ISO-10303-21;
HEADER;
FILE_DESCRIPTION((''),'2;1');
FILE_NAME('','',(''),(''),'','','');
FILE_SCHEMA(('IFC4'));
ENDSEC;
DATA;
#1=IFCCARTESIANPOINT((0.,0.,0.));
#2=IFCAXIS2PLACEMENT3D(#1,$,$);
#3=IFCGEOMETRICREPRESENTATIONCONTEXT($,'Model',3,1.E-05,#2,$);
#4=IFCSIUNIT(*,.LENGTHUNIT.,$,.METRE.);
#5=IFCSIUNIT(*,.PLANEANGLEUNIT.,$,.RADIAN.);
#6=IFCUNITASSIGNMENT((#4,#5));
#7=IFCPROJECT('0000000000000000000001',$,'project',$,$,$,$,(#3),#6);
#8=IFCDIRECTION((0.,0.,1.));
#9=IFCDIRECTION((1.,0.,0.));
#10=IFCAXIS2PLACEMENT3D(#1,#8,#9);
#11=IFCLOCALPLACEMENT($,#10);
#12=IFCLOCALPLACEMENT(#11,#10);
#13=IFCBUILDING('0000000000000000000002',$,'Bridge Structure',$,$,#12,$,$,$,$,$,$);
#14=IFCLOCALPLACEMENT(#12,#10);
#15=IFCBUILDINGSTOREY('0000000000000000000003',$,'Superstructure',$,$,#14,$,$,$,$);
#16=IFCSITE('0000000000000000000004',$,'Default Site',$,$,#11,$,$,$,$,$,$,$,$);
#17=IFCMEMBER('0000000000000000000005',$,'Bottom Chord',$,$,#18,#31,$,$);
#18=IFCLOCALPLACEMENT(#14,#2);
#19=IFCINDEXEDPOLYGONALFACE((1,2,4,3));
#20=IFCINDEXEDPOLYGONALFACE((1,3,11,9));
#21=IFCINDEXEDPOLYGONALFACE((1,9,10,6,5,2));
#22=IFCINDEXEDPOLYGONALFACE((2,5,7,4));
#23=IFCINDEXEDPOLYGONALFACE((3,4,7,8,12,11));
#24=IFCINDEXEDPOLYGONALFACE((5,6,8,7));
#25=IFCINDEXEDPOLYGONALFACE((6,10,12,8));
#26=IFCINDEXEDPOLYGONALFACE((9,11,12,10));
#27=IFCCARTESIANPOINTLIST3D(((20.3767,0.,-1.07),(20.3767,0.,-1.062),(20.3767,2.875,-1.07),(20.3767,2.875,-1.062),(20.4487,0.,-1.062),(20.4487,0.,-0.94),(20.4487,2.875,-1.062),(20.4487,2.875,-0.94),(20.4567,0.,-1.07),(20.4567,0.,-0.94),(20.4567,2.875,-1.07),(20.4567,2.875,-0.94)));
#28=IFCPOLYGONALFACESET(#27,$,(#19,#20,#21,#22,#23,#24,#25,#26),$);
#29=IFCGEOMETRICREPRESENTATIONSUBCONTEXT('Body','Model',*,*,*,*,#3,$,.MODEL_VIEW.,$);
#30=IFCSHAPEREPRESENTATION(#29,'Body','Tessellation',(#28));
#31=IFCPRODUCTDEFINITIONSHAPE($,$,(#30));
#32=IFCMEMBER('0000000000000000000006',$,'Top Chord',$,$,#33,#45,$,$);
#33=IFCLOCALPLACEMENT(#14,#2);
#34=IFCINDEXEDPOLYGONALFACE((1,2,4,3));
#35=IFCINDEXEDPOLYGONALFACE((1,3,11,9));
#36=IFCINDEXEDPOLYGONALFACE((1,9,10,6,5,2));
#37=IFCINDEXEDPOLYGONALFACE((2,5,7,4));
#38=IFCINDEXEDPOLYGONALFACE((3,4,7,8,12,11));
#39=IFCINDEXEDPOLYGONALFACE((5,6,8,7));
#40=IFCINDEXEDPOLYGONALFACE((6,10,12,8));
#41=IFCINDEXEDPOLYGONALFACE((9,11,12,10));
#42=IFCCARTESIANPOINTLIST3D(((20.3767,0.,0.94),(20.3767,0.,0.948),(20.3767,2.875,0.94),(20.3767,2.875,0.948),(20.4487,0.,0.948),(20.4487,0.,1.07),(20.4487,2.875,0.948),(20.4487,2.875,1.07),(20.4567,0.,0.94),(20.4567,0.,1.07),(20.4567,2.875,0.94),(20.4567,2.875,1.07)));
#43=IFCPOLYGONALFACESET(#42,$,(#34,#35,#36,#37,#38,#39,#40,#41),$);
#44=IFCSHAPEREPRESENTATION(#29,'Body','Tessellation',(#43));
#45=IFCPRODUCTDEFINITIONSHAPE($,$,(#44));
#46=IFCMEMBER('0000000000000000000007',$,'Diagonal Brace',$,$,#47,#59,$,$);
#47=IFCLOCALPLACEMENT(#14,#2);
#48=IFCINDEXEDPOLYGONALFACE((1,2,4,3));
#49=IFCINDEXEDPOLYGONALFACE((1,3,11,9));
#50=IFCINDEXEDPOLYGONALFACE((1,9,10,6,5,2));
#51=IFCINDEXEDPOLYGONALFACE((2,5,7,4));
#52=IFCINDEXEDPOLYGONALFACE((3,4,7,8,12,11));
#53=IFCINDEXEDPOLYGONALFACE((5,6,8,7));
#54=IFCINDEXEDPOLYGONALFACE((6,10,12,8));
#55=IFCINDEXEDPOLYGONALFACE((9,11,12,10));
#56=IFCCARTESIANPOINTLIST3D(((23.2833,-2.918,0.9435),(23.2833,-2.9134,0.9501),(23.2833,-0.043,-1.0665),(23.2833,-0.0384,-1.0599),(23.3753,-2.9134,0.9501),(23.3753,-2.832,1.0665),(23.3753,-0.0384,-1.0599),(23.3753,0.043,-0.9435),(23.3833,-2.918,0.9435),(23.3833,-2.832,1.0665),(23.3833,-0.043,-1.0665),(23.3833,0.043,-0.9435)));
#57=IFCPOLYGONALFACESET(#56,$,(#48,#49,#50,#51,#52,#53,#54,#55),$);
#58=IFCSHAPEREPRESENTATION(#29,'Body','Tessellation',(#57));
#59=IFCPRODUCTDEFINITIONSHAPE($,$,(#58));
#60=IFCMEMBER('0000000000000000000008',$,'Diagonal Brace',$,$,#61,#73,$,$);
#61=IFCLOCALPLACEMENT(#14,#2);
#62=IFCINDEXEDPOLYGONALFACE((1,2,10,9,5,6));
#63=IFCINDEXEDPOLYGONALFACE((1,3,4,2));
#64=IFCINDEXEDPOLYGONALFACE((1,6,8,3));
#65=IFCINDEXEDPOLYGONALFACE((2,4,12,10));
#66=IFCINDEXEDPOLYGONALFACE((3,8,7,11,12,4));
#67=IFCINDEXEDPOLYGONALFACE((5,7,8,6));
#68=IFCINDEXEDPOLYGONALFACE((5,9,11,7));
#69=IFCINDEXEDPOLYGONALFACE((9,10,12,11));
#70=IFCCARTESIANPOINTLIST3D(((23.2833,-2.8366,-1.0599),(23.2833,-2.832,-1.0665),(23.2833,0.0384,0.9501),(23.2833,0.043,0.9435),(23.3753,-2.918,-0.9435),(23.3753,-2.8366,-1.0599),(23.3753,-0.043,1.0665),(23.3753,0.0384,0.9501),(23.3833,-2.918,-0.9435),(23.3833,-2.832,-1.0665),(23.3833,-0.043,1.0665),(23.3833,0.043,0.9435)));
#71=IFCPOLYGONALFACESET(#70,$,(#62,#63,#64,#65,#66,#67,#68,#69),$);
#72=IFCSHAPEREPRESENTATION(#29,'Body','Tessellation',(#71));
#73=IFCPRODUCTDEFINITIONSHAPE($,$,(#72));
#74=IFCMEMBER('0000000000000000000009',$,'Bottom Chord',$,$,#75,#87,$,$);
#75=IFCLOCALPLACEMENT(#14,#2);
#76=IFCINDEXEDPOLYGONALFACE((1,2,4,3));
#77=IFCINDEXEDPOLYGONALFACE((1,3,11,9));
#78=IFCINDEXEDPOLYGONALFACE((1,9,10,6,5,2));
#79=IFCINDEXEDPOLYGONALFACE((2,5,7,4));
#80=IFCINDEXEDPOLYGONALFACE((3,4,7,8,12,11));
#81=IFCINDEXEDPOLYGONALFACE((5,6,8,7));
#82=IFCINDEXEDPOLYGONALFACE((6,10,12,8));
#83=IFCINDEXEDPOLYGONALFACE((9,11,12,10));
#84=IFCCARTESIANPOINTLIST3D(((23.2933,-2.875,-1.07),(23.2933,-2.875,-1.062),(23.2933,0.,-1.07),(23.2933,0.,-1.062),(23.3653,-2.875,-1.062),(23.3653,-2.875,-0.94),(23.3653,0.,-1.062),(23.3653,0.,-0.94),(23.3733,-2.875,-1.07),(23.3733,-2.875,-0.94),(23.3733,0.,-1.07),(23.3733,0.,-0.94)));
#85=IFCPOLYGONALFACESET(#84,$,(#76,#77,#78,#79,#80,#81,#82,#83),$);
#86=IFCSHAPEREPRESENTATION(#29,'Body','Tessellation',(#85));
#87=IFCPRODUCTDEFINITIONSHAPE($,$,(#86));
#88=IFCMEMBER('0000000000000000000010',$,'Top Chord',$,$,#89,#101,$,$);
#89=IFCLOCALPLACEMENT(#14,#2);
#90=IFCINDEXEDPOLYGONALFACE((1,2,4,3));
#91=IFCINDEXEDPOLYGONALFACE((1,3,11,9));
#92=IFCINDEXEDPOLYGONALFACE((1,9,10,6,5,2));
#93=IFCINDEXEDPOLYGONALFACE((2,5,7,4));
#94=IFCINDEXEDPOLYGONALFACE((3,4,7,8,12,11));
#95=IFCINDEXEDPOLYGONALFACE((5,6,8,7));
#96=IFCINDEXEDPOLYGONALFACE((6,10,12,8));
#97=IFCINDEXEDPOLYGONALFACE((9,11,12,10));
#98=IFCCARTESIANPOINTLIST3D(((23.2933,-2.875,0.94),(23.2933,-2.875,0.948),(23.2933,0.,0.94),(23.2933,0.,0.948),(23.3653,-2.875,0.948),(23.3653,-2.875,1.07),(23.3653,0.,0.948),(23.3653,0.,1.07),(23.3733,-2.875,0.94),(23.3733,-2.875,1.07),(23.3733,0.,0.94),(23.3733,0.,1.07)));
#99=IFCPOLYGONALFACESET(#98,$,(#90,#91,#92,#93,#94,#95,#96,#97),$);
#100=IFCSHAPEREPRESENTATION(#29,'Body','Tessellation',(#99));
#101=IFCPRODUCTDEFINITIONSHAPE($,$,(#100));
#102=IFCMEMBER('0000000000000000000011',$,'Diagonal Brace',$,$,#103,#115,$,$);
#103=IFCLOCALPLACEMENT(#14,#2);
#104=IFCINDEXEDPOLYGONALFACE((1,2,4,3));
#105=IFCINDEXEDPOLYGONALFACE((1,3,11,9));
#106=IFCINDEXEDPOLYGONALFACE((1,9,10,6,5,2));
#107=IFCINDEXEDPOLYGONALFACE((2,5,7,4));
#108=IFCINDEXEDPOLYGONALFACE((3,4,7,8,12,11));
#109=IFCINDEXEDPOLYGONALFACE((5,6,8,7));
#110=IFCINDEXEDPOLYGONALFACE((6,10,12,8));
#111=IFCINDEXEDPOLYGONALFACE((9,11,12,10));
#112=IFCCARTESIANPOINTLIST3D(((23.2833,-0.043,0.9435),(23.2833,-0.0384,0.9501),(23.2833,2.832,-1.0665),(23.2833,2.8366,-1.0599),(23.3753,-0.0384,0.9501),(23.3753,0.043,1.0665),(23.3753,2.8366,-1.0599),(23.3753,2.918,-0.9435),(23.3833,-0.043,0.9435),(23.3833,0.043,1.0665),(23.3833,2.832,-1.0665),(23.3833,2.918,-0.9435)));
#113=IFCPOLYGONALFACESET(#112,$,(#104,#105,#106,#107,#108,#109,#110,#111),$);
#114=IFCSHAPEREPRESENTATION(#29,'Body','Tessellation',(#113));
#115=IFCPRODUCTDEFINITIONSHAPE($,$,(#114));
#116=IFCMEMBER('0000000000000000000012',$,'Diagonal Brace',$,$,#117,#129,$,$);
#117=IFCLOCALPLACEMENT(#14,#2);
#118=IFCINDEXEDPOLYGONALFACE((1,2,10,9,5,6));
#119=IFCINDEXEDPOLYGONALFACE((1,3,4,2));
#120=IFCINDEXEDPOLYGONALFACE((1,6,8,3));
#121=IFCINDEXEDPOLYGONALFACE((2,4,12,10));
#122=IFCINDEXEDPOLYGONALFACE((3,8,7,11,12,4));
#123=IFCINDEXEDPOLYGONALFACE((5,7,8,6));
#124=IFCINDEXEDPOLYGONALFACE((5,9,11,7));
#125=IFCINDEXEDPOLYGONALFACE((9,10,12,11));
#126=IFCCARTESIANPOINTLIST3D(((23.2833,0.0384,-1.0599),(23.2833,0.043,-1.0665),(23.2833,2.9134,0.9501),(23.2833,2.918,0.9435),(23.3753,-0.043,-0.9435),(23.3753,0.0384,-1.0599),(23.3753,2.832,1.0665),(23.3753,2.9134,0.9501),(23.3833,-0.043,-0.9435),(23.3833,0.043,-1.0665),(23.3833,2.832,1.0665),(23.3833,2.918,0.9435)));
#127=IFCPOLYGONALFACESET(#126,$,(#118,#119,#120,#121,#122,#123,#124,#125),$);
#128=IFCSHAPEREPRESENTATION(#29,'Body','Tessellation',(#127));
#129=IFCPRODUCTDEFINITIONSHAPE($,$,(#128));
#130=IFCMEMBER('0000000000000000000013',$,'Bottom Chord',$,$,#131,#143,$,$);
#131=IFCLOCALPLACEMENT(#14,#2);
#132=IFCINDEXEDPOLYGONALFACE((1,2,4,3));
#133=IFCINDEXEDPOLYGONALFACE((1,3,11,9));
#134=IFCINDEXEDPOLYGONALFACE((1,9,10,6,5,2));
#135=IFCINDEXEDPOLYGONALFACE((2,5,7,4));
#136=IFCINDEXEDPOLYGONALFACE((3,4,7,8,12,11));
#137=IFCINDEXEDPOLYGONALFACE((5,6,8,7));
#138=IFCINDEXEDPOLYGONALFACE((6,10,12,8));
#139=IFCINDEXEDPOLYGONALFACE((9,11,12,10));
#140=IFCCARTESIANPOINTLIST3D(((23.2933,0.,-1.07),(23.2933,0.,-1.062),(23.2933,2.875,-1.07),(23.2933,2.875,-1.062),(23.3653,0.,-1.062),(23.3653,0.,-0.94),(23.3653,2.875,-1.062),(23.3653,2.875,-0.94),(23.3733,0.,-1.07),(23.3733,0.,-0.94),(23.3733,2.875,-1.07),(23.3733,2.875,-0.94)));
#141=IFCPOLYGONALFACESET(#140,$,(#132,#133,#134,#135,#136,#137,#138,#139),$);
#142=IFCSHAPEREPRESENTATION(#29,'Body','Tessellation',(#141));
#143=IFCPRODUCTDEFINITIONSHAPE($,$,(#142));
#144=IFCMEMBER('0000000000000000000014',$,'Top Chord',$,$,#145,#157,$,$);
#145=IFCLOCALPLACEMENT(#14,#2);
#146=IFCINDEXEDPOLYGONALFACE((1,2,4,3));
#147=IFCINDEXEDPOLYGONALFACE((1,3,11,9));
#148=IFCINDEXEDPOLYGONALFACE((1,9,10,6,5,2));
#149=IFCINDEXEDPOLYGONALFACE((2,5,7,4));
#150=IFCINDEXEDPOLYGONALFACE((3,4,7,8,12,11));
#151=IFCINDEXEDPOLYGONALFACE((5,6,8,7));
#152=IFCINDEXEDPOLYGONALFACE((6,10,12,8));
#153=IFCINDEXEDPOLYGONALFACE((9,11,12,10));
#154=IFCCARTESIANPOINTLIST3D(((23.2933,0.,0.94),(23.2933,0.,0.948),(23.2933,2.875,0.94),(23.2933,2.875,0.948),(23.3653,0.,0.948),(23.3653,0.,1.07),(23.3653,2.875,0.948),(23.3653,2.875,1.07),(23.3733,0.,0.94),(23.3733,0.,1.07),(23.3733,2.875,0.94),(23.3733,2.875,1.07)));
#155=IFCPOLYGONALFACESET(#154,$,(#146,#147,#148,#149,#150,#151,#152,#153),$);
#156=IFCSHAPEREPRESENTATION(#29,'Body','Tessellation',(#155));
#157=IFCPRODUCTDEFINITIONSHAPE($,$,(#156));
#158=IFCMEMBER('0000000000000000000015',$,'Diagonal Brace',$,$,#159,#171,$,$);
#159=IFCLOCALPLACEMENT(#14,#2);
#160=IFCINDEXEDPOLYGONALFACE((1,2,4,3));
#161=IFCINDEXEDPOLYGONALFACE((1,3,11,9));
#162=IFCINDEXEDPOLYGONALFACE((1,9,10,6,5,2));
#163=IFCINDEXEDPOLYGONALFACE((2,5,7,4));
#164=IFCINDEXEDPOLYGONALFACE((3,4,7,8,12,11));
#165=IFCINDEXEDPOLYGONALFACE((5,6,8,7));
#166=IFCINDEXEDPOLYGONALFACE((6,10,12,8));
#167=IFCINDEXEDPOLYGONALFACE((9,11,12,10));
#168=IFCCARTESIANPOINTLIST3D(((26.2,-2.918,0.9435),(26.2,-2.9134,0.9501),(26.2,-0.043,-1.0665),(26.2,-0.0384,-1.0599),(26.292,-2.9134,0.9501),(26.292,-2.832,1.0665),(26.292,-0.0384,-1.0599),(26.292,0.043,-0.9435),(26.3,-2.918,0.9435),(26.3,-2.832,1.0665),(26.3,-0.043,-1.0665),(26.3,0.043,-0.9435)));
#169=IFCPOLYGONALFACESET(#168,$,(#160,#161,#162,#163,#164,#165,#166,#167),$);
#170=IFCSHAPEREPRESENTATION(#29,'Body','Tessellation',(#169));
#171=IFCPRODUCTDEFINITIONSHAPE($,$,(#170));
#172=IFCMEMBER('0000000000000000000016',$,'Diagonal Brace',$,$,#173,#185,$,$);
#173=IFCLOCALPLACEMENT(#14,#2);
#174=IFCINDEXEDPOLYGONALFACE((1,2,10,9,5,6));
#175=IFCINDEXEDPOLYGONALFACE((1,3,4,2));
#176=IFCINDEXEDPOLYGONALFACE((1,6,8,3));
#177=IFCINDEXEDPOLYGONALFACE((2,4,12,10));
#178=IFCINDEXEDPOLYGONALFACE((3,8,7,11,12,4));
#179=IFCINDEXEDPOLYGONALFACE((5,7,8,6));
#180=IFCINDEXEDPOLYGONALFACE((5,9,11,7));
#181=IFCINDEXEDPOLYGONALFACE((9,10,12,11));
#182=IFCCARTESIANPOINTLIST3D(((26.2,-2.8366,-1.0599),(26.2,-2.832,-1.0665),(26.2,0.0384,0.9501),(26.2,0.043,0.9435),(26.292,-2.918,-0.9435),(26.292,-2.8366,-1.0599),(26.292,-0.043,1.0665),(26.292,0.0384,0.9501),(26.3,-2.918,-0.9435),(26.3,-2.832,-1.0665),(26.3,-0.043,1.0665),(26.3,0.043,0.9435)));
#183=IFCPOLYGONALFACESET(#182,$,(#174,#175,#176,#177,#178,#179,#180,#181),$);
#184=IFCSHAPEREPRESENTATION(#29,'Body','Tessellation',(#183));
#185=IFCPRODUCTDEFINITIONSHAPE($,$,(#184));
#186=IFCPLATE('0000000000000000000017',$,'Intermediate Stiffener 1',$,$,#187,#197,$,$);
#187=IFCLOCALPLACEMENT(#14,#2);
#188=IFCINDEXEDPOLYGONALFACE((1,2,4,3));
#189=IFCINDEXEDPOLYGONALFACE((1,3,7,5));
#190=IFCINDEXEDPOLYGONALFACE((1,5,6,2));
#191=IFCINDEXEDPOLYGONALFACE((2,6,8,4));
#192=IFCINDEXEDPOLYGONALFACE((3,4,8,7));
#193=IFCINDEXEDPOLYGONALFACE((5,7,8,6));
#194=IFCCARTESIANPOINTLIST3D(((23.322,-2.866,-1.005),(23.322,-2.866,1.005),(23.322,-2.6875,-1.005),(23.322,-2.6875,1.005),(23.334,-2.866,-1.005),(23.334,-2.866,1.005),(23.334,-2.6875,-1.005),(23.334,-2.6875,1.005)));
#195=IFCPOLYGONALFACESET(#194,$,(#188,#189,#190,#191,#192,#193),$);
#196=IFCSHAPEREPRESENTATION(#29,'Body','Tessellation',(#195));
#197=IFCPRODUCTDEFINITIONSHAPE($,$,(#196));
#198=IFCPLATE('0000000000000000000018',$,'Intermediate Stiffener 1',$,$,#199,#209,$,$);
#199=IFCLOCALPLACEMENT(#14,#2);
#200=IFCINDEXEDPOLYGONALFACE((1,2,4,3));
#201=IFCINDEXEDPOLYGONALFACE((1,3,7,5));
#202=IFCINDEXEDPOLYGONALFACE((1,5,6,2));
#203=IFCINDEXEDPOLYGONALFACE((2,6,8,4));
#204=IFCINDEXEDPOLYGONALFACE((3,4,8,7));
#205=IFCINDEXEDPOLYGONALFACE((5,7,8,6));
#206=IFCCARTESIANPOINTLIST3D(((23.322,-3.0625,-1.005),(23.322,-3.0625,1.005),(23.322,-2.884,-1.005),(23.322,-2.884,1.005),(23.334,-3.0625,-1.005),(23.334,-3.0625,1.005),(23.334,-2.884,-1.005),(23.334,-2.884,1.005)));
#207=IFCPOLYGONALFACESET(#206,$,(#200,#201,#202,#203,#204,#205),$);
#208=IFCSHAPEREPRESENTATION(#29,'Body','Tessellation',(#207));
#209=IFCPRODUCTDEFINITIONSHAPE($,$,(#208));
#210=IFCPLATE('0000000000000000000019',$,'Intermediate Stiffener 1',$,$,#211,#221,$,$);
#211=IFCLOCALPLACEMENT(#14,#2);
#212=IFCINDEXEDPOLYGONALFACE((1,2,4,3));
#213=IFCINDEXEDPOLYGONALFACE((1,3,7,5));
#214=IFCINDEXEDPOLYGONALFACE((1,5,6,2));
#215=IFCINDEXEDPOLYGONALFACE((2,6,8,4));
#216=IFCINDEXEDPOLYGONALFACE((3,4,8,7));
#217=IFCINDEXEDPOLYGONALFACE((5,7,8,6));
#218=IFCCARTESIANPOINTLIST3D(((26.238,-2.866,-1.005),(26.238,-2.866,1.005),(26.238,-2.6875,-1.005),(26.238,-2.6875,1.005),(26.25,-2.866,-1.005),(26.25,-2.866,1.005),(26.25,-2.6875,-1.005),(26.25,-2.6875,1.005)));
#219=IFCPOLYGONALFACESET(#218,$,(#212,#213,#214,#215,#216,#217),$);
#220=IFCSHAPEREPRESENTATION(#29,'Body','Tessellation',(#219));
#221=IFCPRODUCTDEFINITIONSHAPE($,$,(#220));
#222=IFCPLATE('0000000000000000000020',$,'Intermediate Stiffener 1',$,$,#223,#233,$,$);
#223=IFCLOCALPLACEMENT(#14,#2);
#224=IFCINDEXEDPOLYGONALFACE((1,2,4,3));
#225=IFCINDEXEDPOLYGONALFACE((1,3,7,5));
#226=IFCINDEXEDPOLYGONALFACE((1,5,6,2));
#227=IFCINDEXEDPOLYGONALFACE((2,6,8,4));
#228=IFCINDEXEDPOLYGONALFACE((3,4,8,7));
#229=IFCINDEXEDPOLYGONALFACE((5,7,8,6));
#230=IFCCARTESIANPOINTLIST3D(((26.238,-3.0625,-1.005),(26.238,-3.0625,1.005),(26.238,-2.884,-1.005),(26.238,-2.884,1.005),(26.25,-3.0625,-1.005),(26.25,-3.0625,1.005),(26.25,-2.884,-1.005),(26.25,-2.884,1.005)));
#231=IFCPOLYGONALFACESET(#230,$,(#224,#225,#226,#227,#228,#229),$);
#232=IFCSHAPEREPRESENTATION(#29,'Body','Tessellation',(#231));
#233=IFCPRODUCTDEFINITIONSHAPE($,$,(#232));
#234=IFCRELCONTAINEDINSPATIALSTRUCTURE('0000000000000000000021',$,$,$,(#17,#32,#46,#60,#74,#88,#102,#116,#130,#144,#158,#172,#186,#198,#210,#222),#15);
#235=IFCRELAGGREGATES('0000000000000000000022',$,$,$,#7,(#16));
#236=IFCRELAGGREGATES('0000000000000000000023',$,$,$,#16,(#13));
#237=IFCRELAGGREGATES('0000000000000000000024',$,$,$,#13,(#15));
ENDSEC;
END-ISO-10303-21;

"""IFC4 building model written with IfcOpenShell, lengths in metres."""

from ifc_helpers import new_model, si_unit, frame, origin, origin_with_axes, origin_2d_with_axis, place, context, subcontext, project, spatial, rectangle, l_section, extrude, element, save


model = new_model("IFC4")

# Units and contexts
model_context = context("Model", 3, precision=1e-05, world=origin())
body_context = subcontext(model_context, "Body", "Model", "MODEL_VIEW")
ifc_project = project(units=[si_unit("LENGTHUNIT", "METRE"), si_unit("PLANEANGLEUNIT", "RADIAN")], contexts=[model_context])

# Site, building, storey
site_placement = place(None, origin_with_axes())
site = spatial("IfcSite", under=ifc_project, at=site_placement, Name="Default Site")
building_placement = place(site_placement, origin_with_axes())
building = spatial("IfcBuilding", under=site, at=building_placement, Name="Bridge Structure")
storey_placement = place(building_placement, origin_with_axes())
storey = spatial("IfcBuildingStorey", under=building, at=storey_placement, Name="Superstructure")

# Members
for number, where, z_axis, x_axis, name in (
    (1, (20.4167, 0.0, -1.005), (0.0, 1.0, 0.0), (-1.0, 0.0, 0.0), "Bottom Chord"),
    (2, (20.4167, 0.0, 1.005), (0.0, 1.0, 0.0), (-1.0, 0.0, 0.0), "Top Chord"),
):
    element("IfcMember", number, at=place(storey_placement, frame(where, z_axis=z_axis, x_axis=x_axis)), inside=storey, Name=name, context=body_context, shape_type="SweptSolid", body=[
        extrude(l_section(Depth=0.13, Width=0.08, Thickness=0.008, at=origin_2d_with_axis()), origin_with_axes(), (0.0, 0.0, 1.0), 2.875),
    ])
for number, where, z_axis, x_axis, name in (
    (3, (23.3333, -2.875, 1.005), (0.0, 0.819567, -0.572984), (-1.0, 0.0, 0.0), "Diagonal Brace"),
    (4, (23.3333, -2.875, -1.005), (0.0, 0.819567, 0.572984), (-1.0, 0.0, 0.0), "Diagonal Brace"),
):
    element("IfcMember", number, at=place(storey_placement, frame(where, z_axis=z_axis, x_axis=x_axis)), inside=storey, Name=name, context=body_context, shape_type="SweptSolid", body=[
        extrude(l_section(Depth=0.15, Width=0.1, Thickness=0.008, at=origin_2d_with_axis()), origin_with_axes(), (0.0, 0.0, 1.0), 3.508),
    ])
for number, where, z_axis, x_axis, name in (
    (5, (23.3333, -2.875, -1.005), (0.0, 1.0, 0.0), (-1.0, 0.0, 0.0), "Bottom Chord"),
    (6, (23.3333, -2.875, 1.005), (0.0, 1.0, 0.0), (-1.0, 0.0, 0.0), "Top Chord"),
):
    element("IfcMember", number, at=place(storey_placement, frame(where, z_axis=z_axis, x_axis=x_axis)), inside=storey, Name=name, context=body_context, shape_type="SweptSolid", body=[
        extrude(l_section(Depth=0.13, Width=0.08, Thickness=0.008, at=origin_2d_with_axis()), origin_with_axes(), (0.0, 0.0, 1.0), 2.875),
    ])
for number, where, z_axis, x_axis, name in (
    (7, (23.3333, 0.0, 1.005), (0.0, 0.819567, -0.572984), (-1.0, 0.0, 0.0), "Diagonal Brace"),
    (8, (23.3333, 0.0, -1.005), (0.0, 0.819567, 0.572984), (-1.0, 0.0, 0.0), "Diagonal Brace"),
):
    element("IfcMember", number, at=place(storey_placement, frame(where, z_axis=z_axis, x_axis=x_axis)), inside=storey, Name=name, context=body_context, shape_type="SweptSolid", body=[
        extrude(l_section(Depth=0.15, Width=0.1, Thickness=0.008, at=origin_2d_with_axis()), origin_with_axes(), (0.0, 0.0, 1.0), 3.508),
    ])
for number, where, z_axis, x_axis, name in (
    (9, (23.3333, 0.0, -1.005), (0.0, 1.0, 0.0), (-1.0, 0.0, 0.0), "Bottom Chord"),
    (10, (23.3333, 0.0, 1.005), (0.0, 1.0, 0.0), (-1.0, 0.0, 0.0), "Top Chord"),
):
    element("IfcMember", number, at=place(storey_placement, frame(where, z_axis=z_axis, x_axis=x_axis)), inside=storey, Name=name, context=body_context, shape_type="SweptSolid", body=[
        extrude(l_section(Depth=0.13, Width=0.08, Thickness=0.008, at=origin_2d_with_axis()), origin_with_axes(), (0.0, 0.0, 1.0), 2.875),
    ])
for number, where, z_axis, x_axis, name in (
    (11, (26.25, -2.875, 1.005), (0.0, 0.819567, -0.572984), (-1.0, 0.0, 0.0), "Diagonal Brace"),
    (12, (26.25, -2.875, -1.005), (0.0, 0.819567, 0.572984), (-1.0, 0.0, 0.0), "Diagonal Brace"),
):
    element("IfcMember", number, at=place(storey_placement, frame(where, z_axis=z_axis, x_axis=x_axis)), inside=storey, Name=name, context=body_context, shape_type="SweptSolid", body=[
        extrude(l_section(Depth=0.15, Width=0.1, Thickness=0.008, at=origin_2d_with_axis()), origin_with_axes(), (0.0, 0.0, 1.0), 3.508),
    ])

# Plates
for number, where, z_axis, x_axis, name in (
    (13, (23.328, -2.7768, -1.005), (0.0, 0.0, 1.0), (1.0, 0.0, 0.0), "Intermediate Stiffener 1"),
    (14, (23.328, -2.9733, -1.005), (0.0, 0.0, 1.0), (1.0, 0.0, 0.0), "Intermediate Stiffener 1"),
    (15, (26.244, -2.7768, -1.005), (0.0, 0.0, 1.0), (1.0, 0.0, 0.0), "Intermediate Stiffener 1"),
    (16, (26.244, -2.9733, -1.005), (0.0, 0.0, 1.0), (1.0, 0.0, 0.0), "Intermediate Stiffener 1"),
):
    element("IfcPlate", number, at=place(storey_placement, frame(where, z_axis=z_axis, x_axis=x_axis)), inside=storey, Name=name, context=body_context, shape_type="SweptSolid", body=[
        extrude(rectangle(XDim=0.012, YDim=0.1785, at=origin_2d_with_axis()), origin_with_axes(), (0.0, 0.0, 1.0), 2.01),
    ])

save(model, "model.ifc")
